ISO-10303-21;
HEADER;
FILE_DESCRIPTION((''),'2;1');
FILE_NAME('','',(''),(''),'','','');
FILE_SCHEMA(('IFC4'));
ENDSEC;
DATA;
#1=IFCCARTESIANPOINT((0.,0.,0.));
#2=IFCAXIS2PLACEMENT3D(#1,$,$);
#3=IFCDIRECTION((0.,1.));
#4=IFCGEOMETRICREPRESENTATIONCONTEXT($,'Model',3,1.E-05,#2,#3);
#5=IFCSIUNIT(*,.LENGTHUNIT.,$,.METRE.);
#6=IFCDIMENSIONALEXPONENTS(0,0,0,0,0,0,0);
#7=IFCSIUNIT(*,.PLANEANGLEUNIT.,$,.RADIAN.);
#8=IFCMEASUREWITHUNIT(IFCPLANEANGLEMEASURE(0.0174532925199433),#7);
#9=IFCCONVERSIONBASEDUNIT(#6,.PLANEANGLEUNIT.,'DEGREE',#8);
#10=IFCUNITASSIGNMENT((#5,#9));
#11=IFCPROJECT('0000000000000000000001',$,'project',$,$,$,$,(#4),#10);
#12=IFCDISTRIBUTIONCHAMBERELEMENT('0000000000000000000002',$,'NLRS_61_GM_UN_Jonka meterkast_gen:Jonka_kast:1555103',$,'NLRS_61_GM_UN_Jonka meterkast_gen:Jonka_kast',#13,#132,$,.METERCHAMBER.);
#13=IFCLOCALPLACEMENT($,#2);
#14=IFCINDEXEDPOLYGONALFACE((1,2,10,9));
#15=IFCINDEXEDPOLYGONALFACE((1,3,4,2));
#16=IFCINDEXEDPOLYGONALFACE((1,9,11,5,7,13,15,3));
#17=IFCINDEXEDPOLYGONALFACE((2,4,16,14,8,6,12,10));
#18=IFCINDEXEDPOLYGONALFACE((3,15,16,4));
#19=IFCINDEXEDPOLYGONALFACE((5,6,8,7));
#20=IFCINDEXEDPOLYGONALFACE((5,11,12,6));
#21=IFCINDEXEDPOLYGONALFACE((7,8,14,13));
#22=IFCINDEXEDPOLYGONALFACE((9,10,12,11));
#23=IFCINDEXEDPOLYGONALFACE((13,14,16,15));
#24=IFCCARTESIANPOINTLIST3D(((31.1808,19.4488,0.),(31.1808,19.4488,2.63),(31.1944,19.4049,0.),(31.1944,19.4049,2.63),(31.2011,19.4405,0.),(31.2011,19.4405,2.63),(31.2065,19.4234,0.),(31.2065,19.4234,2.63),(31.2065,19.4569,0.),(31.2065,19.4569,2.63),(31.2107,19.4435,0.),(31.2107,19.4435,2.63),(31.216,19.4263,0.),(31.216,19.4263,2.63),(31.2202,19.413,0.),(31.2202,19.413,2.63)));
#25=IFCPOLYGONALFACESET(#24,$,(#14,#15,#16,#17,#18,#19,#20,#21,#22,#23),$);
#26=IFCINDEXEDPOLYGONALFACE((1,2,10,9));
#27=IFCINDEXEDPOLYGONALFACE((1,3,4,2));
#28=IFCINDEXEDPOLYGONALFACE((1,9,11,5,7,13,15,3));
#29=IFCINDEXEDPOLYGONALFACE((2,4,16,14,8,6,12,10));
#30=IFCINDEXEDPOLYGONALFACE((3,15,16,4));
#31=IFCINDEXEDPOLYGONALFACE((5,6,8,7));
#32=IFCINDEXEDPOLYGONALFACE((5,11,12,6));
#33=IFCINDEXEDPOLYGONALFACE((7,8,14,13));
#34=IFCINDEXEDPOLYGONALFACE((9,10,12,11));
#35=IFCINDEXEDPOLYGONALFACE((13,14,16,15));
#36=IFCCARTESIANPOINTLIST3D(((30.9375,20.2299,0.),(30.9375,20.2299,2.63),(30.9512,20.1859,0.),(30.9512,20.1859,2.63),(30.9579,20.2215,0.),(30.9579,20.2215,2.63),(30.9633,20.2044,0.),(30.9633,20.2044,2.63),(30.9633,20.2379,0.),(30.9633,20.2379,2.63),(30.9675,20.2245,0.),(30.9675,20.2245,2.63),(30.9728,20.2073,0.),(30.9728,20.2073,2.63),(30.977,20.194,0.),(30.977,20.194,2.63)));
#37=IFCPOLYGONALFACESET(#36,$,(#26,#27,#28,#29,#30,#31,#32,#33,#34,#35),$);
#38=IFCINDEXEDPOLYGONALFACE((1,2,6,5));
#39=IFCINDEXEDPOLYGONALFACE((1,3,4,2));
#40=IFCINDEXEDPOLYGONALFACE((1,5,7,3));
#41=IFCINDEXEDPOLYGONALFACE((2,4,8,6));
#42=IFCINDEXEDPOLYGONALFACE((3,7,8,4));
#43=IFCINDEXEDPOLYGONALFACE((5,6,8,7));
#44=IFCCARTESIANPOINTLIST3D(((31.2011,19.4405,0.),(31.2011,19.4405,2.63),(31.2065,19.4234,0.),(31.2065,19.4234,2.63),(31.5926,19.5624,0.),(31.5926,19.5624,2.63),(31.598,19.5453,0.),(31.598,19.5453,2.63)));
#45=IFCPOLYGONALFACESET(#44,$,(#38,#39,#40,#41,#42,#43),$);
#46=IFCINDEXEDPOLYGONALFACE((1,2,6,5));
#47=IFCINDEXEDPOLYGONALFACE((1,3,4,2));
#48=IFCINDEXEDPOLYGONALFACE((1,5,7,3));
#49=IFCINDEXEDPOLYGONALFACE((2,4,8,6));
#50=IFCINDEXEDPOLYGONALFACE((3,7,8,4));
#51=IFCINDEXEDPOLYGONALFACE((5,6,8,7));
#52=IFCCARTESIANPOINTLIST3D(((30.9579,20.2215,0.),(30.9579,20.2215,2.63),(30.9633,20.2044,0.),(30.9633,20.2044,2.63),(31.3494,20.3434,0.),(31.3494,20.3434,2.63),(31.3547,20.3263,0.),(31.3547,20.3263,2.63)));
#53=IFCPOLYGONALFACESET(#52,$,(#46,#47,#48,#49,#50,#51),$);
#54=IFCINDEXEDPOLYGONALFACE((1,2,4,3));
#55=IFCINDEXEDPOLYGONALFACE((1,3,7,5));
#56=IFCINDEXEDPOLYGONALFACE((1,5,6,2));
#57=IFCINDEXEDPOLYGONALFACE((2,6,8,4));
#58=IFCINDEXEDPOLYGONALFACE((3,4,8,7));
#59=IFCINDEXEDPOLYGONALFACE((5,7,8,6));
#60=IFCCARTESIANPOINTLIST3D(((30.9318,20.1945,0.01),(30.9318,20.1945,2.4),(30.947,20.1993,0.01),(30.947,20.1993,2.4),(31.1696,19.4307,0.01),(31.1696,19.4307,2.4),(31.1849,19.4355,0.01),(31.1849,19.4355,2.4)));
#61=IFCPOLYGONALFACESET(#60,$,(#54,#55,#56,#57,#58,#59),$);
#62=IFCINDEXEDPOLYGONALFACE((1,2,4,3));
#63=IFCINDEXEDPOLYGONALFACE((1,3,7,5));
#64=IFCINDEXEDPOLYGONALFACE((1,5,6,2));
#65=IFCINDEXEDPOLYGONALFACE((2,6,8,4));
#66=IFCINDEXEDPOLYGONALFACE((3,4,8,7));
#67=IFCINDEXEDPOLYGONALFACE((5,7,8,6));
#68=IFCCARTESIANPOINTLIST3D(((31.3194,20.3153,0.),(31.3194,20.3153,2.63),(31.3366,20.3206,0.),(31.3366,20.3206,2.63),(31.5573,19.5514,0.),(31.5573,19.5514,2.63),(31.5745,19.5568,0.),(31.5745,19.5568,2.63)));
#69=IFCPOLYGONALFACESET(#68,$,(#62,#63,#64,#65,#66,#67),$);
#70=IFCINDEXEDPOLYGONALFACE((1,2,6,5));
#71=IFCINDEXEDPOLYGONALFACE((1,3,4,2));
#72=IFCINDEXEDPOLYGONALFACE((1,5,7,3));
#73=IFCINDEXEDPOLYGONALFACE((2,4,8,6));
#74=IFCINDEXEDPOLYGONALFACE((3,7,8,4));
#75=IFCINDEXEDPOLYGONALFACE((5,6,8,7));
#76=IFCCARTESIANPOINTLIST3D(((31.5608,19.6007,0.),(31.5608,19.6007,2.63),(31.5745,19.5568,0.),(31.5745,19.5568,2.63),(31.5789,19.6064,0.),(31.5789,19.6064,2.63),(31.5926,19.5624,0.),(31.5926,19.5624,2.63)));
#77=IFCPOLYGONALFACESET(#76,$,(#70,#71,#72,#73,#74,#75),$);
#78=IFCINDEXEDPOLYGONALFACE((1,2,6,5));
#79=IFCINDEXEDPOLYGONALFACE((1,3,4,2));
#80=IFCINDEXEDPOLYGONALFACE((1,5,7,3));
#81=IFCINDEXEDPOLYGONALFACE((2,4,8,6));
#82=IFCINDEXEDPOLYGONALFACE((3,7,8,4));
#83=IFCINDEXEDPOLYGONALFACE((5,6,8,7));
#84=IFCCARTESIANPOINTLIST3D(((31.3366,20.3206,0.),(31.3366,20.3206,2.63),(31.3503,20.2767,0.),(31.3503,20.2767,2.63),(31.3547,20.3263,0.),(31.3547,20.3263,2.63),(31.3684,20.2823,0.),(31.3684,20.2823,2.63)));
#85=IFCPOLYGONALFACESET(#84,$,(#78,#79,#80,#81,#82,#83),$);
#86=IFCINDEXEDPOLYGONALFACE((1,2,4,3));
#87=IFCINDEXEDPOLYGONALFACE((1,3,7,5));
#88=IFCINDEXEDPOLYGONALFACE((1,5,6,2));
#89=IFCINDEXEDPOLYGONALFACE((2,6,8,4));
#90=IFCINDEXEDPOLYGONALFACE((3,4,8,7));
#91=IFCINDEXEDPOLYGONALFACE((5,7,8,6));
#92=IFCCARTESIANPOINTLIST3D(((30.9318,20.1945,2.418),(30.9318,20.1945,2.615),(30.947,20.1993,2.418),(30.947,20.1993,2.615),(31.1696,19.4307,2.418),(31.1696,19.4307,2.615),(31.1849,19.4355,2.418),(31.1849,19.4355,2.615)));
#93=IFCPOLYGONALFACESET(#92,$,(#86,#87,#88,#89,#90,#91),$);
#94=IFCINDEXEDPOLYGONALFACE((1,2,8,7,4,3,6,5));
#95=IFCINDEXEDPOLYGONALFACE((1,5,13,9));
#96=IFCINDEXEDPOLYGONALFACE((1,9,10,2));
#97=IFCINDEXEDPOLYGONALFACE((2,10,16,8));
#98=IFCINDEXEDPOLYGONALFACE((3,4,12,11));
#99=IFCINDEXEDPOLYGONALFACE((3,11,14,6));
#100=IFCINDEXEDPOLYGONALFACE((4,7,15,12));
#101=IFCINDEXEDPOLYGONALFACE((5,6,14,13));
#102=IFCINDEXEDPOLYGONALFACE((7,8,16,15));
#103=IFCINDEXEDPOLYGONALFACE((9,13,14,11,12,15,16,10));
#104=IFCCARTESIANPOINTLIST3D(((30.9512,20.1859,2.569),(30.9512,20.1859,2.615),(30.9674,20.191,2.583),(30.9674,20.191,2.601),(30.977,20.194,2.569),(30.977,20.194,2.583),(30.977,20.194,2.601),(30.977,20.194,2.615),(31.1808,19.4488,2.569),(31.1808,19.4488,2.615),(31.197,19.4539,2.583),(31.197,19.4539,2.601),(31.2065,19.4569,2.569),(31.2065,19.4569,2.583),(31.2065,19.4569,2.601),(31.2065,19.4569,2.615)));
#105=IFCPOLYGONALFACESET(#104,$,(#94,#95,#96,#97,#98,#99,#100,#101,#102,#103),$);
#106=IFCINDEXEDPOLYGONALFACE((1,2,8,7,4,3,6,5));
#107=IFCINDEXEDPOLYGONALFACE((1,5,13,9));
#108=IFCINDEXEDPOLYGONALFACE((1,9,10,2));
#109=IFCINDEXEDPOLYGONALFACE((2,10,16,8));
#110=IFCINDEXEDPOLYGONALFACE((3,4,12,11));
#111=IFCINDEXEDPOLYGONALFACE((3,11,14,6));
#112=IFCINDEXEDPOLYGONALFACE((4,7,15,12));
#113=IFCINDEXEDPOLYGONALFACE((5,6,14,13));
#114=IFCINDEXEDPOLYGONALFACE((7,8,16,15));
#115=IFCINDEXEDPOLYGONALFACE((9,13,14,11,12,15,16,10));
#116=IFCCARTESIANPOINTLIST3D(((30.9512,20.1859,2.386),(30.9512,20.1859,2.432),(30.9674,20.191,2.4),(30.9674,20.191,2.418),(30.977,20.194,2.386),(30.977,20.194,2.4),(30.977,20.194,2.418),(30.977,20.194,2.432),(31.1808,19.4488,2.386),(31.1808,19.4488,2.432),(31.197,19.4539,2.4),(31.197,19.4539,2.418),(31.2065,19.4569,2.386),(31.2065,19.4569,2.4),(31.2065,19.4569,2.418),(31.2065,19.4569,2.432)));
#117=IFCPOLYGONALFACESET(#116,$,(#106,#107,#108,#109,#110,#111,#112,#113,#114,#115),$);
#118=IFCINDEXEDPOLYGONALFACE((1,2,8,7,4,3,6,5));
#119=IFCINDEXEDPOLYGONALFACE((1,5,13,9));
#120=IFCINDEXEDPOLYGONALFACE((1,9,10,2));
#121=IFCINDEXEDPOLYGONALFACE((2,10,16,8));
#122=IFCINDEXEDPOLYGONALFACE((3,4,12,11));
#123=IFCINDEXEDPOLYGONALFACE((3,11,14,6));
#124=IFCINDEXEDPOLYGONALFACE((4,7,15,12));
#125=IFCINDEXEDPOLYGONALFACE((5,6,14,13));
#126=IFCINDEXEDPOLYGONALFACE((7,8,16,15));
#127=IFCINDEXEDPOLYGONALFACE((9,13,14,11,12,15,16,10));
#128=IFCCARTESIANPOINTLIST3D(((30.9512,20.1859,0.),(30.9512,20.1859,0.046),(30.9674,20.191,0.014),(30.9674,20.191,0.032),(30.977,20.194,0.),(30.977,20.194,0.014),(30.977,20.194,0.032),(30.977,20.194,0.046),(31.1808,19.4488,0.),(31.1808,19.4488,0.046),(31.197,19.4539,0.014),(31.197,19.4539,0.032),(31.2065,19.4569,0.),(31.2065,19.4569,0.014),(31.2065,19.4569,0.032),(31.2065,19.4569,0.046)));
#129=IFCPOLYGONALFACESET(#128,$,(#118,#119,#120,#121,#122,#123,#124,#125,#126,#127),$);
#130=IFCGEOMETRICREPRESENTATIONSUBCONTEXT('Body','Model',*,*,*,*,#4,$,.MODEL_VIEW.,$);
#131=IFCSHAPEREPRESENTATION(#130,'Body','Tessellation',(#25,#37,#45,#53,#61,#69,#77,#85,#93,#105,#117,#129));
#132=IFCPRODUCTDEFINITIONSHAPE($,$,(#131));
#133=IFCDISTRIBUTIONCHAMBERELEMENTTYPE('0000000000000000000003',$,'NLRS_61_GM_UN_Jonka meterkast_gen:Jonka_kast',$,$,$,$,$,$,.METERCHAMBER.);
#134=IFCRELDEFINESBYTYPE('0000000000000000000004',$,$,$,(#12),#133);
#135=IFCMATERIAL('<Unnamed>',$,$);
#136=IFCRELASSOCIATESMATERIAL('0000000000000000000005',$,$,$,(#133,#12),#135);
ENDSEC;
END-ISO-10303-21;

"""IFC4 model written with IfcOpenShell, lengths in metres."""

from ifc_helpers import new_model, entity, si_unit, converted_unit, direction, frame, origin, place, context, subcontext, project, indexed_curve, outline, extrude, source, transform, mapped, material, type_object, element, save


model = new_model("IFC4")

# Units and contexts
model_context = context("Model", 3, precision=1e-05, world=origin(), true_north=direction((0.0, 1.0)))
body_context = subcontext(model_context, "Body", "Model", "MODEL_VIEW")
ifc_project = project(units=[si_unit("LENGTHUNIT", "METRE"), converted_unit("PLANEANGLEUNIT", "DEGREE", entity("IfcPlaneAngleMeasure", 0.0174532925199433), si_unit("PLANEANGLEUNIT", "RADIAN"), dimensions=[0, 0, 0, 0, 0, 0, 0])], contexts=[model_context])

# Shared definitions
ifc_material = material(Name="<Unnamed>")
distribution_chamber_element_type = type_object("IfcDistributionChamberElementType", Name="NLRS_61_GM_UN_Jonka meterkast_gen:Jonka_kast", PredefinedType="METERCHAMBER", material=ifc_material)
placement_1 = place(None, frame((13.1348, 11.9886, 0.0), z_axis=(0.0, 0.0, 1.0), x_axis=(0.954771, 0.297342, 0.0)))
placement_2 = place(placement_1, origin())

# Distribution chamber element
shared_shape_1 = source(origin(), body_context, "Body", "SweptSolid", [
    extrude(outline(indexed_curve([(-0.023, -0.0093), (-0.009, -0.0093), (-0.009, 0.0007), (0.009, 0.0007), (0.009, -0.0093), (0.023, -0.0093), (0.023, 0.0178), (-0.023, 0.0178), (-0.023, -0.0093)], self_intersect=False)), frame((-0.409, 0.4092, 0.0)), (0.0, 0.0, 1.0), 2.63),
    extrude(outline(indexed_curve([(-0.023, -0.0093), (-0.009, -0.0093), (-0.009, 0.0007), (0.009, 0.0007), (0.009, -0.0093), (0.023, -0.0093), (0.023, 0.0178), (-0.023, 0.0178), (-0.023, -0.0093)], self_intersect=False)), frame((0.409, 0.4092, 0.0)), (0.0, 0.0, 1.0), 2.63),
    extrude(outline(indexed_curve([(-0.009, -0.205), (0.009, -0.205), (0.009, 0.205), (-0.009, 0.205), (-0.009, -0.205)], self_intersect=False)), frame((-0.409, 0.205, 0.0)), (0.0, 0.0, 1.0), 2.63),
    extrude(outline(indexed_curve([(-0.009, -0.205), (0.009, -0.205), (0.009, 0.205), (-0.009, 0.205), (-0.009, -0.205)], self_intersect=False)), frame((0.409, 0.205, 0.0)), (0.0, 0.0, 1.0), 2.63),
    extrude(outline(indexed_curve([(-0.008, -0.4), (0.008, -0.4), (0.008, 0.4), (-0.008, 0.4), (-0.008, -0.4)], self_intersect=False)), frame((0.0, 0.435, 0.01), z_axis=(0.0, 0.0, 1.0), x_axis=(0.0, 1.0, 0.0)), (0.0, 0.0, 1.0), 2.39),
    extrude(outline(indexed_curve([(-0.009, -0.4), (0.009, -0.4), (0.009, 0.4), (-0.009, 0.4), (-0.009, -0.4)], self_intersect=False)), frame((0.0, 0.028, 0.0), z_axis=(0.0, 0.0, 1.0), x_axis=(0.0, 1.0, 0.0)), (0.0, 0.0, 1.0), 2.63),
    extrude(outline(indexed_curve([(-0.0095, -0.023), (0.0095, -0.023), (0.0095, 0.023), (-0.0095, 0.023), (-0.0095, -0.023)], self_intersect=False)), frame((-0.377, 0.0095, 0.0), z_axis=(0.0, 0.0, 1.0), x_axis=(0.0, 1.0, 0.0)), (0.0, 0.0, 1.0), 2.63),
    extrude(outline(indexed_curve([(-0.0095, -0.023), (0.0095, -0.023), (0.0095, 0.023), (-0.0095, 0.023), (-0.0095, -0.023)], self_intersect=False)), frame((0.377, 0.0095, 0.0), z_axis=(0.0, 0.0, 1.0), x_axis=(0.0, 1.0, 0.0)), (0.0, 0.0, 1.0), 2.63),
    extrude(outline(indexed_curve([(-0.008, -0.4), (0.008, -0.4), (0.008, 0.4), (-0.008, 0.4), (-0.008, -0.4)], self_intersect=False)), frame((0.0, 0.435, 2.418), z_axis=(0.0, 0.0, 1.0), x_axis=(0.0, 1.0, 0.0)), (0.0, 0.0, 1.0), 0.197),
    extrude(outline(indexed_curve([(-0.0178, -0.023), (0.0093, -0.023), (0.0093, -0.009), (-0.0007, -0.009), (-0.0007, 0.009), (0.0093, 0.009), (0.0093, 0.023), (-0.0178, 0.023), (-0.0178, -0.023)], self_intersect=False)), frame((-0.386, 0.4092, 2.592), z_axis=(1.0, 0.0, 0.0), x_axis=(0.0, -1.0, 0.0)), (0.0, 0.0, 1.0), 0.772),
    extrude(outline(indexed_curve([(-0.0178, -0.023), (0.0093, -0.023), (0.0093, -0.009), (-0.0007, -0.009), (-0.0007, 0.009), (0.0093, 0.009), (0.0093, 0.023), (-0.0178, 0.023), (-0.0178, -0.023)], self_intersect=False)), frame((-0.386, 0.4092, 2.409), z_axis=(1.0, 0.0, 0.0), x_axis=(0.0, -1.0, 0.0)), (0.0, 0.0, 1.0), 0.772),
    extrude(outline(indexed_curve([(-0.0178, -0.023), (0.0093, -0.023), (0.0093, -0.009), (-0.0007, -0.009), (-0.0007, 0.009), (0.0093, 0.009), (0.0093, 0.023), (-0.0178, 0.023), (-0.0178, -0.023)], self_intersect=False)), frame((-0.386, 0.4092, 0.023), z_axis=(1.0, 0.0, 0.0), x_axis=(0.0, -1.0, 0.0)), (0.0, 0.0, 1.0), 0.772),
])
placement_3 = place(placement_2, origin())
placement_4 = place(placement_3, origin())
distribution_chamber_element_1_placement = place(placement_4, frame((19.875, 2.143, 0.0), z_axis=(0.0, 0.0, 1.0), x_axis=(0.0, 1.0, 0.0)))
element("IfcDistributionChamberElement", 1, at=distribution_chamber_element_1_placement, type_object=distribution_chamber_element_type, material=ifc_material, Name="NLRS_61_GM_UN_Jonka meterkast_gen:Jonka_kast:1555103", ObjectType="NLRS_61_GM_UN_Jonka meterkast_gen:Jonka_kast", PredefinedType="METERCHAMBER", context=body_context, shape_type="MappedRepresentation", body=[
    mapped(shared_shape_1, transform((0.0, 0.0, 0.0), scale=1.0)),
])

save(model, "model.ifc")
